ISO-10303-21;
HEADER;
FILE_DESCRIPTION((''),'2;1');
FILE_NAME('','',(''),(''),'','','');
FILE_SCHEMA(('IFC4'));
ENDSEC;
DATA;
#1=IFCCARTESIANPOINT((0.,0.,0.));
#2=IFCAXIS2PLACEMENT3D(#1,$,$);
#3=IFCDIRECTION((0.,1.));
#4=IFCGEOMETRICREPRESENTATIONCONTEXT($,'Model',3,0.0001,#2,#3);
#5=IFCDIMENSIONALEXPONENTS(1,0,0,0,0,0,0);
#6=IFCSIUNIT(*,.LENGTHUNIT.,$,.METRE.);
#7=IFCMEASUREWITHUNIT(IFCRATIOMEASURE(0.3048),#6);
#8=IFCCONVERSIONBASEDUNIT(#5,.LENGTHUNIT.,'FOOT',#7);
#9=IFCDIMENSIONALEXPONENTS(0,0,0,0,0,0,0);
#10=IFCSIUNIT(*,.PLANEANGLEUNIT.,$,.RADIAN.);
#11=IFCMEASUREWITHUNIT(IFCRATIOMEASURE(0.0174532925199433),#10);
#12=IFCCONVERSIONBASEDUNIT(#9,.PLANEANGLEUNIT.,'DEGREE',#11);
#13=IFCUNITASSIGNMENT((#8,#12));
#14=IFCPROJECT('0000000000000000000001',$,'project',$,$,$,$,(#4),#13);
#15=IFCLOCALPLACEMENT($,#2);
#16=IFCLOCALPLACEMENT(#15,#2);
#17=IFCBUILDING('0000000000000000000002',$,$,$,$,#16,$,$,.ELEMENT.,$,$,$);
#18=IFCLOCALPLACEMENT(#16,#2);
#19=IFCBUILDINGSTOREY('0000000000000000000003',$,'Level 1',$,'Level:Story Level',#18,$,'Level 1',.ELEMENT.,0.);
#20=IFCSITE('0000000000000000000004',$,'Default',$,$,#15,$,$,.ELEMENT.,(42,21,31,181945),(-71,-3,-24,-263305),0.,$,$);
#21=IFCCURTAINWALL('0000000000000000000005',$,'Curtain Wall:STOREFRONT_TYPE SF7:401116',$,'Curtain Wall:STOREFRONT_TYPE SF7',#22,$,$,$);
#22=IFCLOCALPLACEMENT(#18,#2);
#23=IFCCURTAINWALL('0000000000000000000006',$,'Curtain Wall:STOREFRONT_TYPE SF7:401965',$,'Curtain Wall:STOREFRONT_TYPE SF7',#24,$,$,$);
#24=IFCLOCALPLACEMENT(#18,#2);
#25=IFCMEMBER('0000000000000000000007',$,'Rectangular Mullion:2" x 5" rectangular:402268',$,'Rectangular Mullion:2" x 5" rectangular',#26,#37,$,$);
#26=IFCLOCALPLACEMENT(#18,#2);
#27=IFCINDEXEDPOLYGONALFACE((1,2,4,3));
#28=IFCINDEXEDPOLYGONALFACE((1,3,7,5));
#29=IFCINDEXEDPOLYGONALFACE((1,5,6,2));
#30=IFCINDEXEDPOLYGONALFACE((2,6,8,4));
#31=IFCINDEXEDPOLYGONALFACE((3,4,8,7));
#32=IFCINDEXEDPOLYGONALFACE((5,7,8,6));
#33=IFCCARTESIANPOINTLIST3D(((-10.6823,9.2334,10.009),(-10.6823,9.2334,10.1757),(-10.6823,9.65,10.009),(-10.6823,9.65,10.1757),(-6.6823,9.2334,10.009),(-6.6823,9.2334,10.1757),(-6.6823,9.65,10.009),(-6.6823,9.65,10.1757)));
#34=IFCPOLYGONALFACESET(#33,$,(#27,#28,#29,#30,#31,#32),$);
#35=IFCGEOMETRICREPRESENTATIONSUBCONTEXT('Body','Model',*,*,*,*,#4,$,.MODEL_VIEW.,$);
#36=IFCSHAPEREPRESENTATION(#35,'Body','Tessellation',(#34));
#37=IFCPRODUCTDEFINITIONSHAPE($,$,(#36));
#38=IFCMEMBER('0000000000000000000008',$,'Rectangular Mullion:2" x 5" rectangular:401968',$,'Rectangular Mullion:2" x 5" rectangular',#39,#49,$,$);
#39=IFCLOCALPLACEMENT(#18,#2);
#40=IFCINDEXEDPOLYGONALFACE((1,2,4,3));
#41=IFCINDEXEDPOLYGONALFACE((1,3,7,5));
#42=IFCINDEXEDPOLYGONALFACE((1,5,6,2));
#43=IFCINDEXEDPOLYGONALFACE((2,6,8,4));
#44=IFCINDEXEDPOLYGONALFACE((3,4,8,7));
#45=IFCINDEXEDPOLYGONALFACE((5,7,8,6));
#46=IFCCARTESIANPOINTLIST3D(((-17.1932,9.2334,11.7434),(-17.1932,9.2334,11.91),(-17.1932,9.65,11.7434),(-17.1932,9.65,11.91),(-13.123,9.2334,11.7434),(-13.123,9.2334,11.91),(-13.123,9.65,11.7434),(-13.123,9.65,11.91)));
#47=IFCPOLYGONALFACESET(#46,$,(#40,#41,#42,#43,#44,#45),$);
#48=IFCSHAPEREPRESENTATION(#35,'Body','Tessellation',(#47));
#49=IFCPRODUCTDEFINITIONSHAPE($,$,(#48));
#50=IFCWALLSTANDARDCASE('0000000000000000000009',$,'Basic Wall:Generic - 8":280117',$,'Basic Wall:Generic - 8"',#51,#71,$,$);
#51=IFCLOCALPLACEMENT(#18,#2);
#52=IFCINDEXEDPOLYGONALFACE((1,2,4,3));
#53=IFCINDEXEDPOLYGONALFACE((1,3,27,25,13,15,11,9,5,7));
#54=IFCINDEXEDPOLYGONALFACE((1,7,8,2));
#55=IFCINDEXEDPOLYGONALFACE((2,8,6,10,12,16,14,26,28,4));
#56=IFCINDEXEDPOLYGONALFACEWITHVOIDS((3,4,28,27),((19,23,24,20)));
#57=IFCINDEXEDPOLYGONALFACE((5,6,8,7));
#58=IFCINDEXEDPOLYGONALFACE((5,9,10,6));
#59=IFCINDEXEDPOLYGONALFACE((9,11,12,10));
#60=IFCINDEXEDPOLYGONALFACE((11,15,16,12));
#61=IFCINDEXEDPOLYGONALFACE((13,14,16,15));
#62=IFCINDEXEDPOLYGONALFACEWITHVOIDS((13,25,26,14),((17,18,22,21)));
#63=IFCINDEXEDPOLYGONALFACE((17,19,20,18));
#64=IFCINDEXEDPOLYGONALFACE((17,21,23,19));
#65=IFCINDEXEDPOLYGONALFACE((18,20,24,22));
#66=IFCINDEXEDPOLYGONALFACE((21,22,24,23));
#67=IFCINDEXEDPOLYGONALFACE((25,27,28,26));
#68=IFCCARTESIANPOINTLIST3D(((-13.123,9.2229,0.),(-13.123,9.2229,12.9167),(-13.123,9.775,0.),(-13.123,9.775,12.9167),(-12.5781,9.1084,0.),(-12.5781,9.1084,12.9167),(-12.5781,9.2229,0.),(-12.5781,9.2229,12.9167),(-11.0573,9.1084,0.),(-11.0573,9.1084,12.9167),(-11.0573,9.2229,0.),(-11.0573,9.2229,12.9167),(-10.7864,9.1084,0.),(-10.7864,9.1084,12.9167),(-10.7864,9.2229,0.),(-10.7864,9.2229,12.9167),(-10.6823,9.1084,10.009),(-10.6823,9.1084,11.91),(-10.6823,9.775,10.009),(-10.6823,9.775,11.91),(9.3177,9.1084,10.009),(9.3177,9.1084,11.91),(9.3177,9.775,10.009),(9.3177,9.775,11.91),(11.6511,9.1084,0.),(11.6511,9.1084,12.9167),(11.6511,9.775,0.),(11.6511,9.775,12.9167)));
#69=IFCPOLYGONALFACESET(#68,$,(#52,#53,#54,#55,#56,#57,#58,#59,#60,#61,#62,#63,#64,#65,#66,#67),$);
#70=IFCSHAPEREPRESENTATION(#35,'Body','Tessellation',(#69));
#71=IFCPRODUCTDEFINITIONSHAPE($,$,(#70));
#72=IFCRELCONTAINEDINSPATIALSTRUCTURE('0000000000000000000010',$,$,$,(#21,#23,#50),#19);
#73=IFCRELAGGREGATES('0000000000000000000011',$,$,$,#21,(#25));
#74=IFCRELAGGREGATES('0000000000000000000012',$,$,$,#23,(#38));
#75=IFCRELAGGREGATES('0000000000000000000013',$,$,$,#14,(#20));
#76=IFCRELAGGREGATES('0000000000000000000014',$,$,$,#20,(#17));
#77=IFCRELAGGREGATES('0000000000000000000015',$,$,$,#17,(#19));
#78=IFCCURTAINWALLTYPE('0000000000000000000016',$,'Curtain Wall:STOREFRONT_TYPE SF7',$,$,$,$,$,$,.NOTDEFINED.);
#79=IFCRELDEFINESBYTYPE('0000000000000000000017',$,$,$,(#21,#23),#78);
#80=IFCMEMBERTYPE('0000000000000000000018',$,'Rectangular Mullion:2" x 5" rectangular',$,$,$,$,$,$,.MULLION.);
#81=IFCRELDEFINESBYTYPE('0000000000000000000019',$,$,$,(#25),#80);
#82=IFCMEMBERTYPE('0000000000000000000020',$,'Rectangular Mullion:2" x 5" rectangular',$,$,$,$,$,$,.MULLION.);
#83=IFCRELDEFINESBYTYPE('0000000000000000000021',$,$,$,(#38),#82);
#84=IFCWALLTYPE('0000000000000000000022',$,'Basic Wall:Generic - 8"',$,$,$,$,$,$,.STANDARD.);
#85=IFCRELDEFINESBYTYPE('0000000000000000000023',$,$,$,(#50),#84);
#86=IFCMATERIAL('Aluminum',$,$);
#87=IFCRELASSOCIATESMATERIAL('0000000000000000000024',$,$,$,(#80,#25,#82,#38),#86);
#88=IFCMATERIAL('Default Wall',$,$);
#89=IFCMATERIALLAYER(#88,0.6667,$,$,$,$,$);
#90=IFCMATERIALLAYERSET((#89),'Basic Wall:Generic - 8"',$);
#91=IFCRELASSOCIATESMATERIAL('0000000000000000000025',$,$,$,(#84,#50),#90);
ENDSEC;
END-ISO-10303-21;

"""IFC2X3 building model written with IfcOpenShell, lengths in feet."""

from ifc_helpers import new_model, entity, si_unit, converted_unit, direction, frame, frame_2d, origin, origin_2d_with_axis, place, context, subcontext, project, spatial, polyline, rectangle, extrude, clip, bounded_halfspace, source, transform, mapped, material, layer, layer_set, layer_usage, type_object, type_shapes, element, aggregate, save


model = new_model("IFC2X3")

# Units and contexts
model_context = context("Model", 3, precision=0.0001, world=origin(), true_north=direction((0.0, 1.0)))
body_context = subcontext(model_context, "Body", "Model", "MODEL_VIEW")
ifc_project = project(units=[converted_unit("LENGTHUNIT", "FOOT", entity("IfcRatioMeasure", 0.3048), si_unit("LENGTHUNIT", "METRE"), dimensions=[1, 0, 0, 0, 0, 0, 0]), converted_unit("PLANEANGLEUNIT", "DEGREE", entity("IfcRatioMeasure", 0.0174532925199433), si_unit("PLANEANGLEUNIT", "RADIAN"), dimensions=[0, 0, 0, 0, 0, 0, 0])], contexts=[model_context])

# Site, building, storey
site_placement = place(None, origin())
site = spatial("IfcSite", under=ifc_project, at=site_placement, Name="Default", CompositionType="ELEMENT", RefLatitude=(42, 21, 31, 181945), RefLongitude=(-71, -3, -24, -263305), RefElevation=0.0)
building_placement = place(site_placement, origin())
building = spatial("IfcBuilding", under=site, at=building_placement, CompositionType="ELEMENT")
storey_placement = place(building_placement, origin())
storey = spatial("IfcBuildingStorey", under=building, at=storey_placement, Name="Level 1", ObjectType="Level:Story Level", LongName="Level 1", CompositionType="ELEMENT", Elevation=0.0)

# Curtain wall
curtain_wall_type = type_object("IfcCurtainWallType", Name="Curtain Wall:STOREFRONT_TYPE SF7", PredefinedType="NOTDEFINED")
curtain_wall_1_placement = place(storey_placement, origin())
curtain_wall_1 = element("IfcCurtainWall", 1, at=curtain_wall_1_placement, inside=storey, type_object=curtain_wall_type, Name="Curtain Wall:STOREFRONT_TYPE SF7:401116", ObjectType="Curtain Wall:STOREFRONT_TYPE SF7")
ifc_material_1 = material(Name="Aluminum")

# Curtain wall
curtain_wall_2_placement = place(storey_placement, origin())
curtain_wall_2 = element("IfcCurtainWall", 2, at=curtain_wall_2_placement, inside=storey, type_object=curtain_wall_type, Name="Curtain Wall:STOREFRONT_TYPE SF7:401965", ObjectType="Curtain Wall:STOREFRONT_TYPE SF7")

# Members
member_type_1 = type_object("IfcMemberType", Name="Rectangular Mullion:2\" x 5\" rectangular", PredefinedType="MULLION", material=ifc_material_1)
shared_shape_1 = source(origin(), body_context, "Body", "SweptSolid", [
    extrude(rectangle(XDim=0.4167, YDim=0.1667, at=origin_2d_with_axis()), frame((-0.0833, 0.0, -4.0), z_axis=(0.0, 0.0, 1.0), x_axis=(0.0, -1.0, 0.0)), (0.0, 0.0, 1.0), 4.0),
])
type_shapes(member_type_1, [shared_shape_1])
member_1_placement = place(curtain_wall_1_placement, frame((-6.6823, 9.4417, 10.009), z_axis=(1.0, 0.0, 0.0), x_axis=(0.0, 0.0, -1.0)))
member_1 = element("IfcMember", 3, at=member_1_placement, type_object=member_type_1, material=ifc_material_1, Name="Rectangular Mullion:2\" x 5\" rectangular:402268", ObjectType="Rectangular Mullion:2\" x 5\" rectangular", context=body_context, shape_type="MappedRepresentation", body=[
    mapped(shared_shape_1, transform((0.0, 0.0, 0.0), scale=1.0)),
])
member_type_2 = type_object("IfcMemberType", Name="Rectangular Mullion:2\" x 5\" rectangular", PredefinedType="MULLION", material=ifc_material_1)
shared_shape_2 = source(origin(), body_context, "Body", "SweptSolid", [
    extrude(rectangle(XDim=0.4167, YDim=0.1667, at=origin_2d_with_axis()), frame((-0.0833, 0.0, -4.0702), z_axis=(0.0, 0.0, 1.0), x_axis=(0.0, -1.0, 0.0)), (0.0, 0.0, 1.0), 4.0702),
])
type_shapes(member_type_2, [shared_shape_2])
member_2_placement = place(curtain_wall_2_placement, frame((-13.123, 9.4417, 11.91), z_axis=(1.0, 0.0, 0.0), x_axis=(0.0, 0.0, 1.0)))
member_2 = element("IfcMember", 4, at=member_2_placement, type_object=member_type_2, material=ifc_material_1, Name="Rectangular Mullion:2\" x 5\" rectangular:401968", ObjectType="Rectangular Mullion:2\" x 5\" rectangular", context=body_context, shape_type="MappedRepresentation", body=[
    mapped(shared_shape_2, transform((0.0, 0.0, 0.0), scale=1.0)),
])

aggregate(curtain_wall_1, [member_1])
aggregate(curtain_wall_2, [member_2])

# Wall, opening
ifc_material_2 = material(Name="Default Wall")
ifc_layer_1 = layer(ifc_material_2, 0.6667)
ifc_layer_set_1 = layer_set([ifc_layer_1], Name="Basic Wall:Generic - 8\"")
ifc_layer_usage_1 = layer_usage(ifc_layer_set_1, "AXIS2", "NEGATIVE", 0.3333)
wall_type_1 = type_object("IfcWallType", Name="Basic Wall:Generic - 8\"", PredefinedType="STANDARD", material=ifc_layer_set_1)
wall_1_placement = place(storey_placement, frame((-13.123, 9.4417, 0.0)))
wall_1 = element("IfcWallStandardCase", 5, at=wall_1_placement, inside=storey, type_object=wall_type_1, material=ifc_layer_usage_1, Name="Basic Wall:Generic - 8\":280117", ObjectType="Basic Wall:Generic - 8\"", context=body_context, shape_type="Clipping", body=[
    clip(clip(clip(extrude(rectangle(XDim=24.7741, YDim=0.6667, at=frame_2d((12.387, 0.0), x_axis=(-1.0, 0.0))), origin(), (0.0, 0.0, 1.0), 12.9167), bounded_halfspace(frame((0.5449, -0.2188, 0.0), z_axis=(0.0, 1.0, 0.0), x_axis=(-1.0, 0.0, 0.0)), True, frame((0.5449, -0.2188, 0.0), z_axis=(0.0, 1.0, 0.0), x_axis=(-1.0, 0.0, 0.0)), polyline([(0.0, 0.0), (0.5449, 0.0), (0.5449, 12.9167), (0.0, 12.9167), (0.0, 0.0)]))), bounded_halfspace(frame((0.5449, -0.2188, 12.9167), z_axis=(-1.0, 0.0, 0.0), x_axis=(0.0, -1.0, 0.0)), False, frame((0.5449, -0.2188, 12.9167), z_axis=(-1.0, 0.0, 0.0), x_axis=(0.0, -1.0, 0.0)), polyline([(0.0, 0.0), (0.0, -12.9167), (0.1146, -12.9167), (0.1146, 0.0), (0.0, 0.0)]))), bounded_halfspace(frame((2.0657, -0.2188, 12.9167), z_axis=(0.0, 1.0, 0.0), x_axis=(-1.0, 0.0, 0.0)), True, frame((2.0657, -0.2188, 12.9167), z_axis=(0.0, 1.0, 0.0), x_axis=(-1.0, 0.0, 0.0)), polyline([(0.0, 0.0), (-0.2708, 0.0), (-0.2708, -12.9167), (0.0, -12.9167), (0.0, 0.0)]))),
])
opening_1_placement = place(wall_1_placement, origin())
element("IfcOpeningElement", 6, at=opening_1_placement, cuts=wall_1, ObjectType="Opening", context=body_context, shape_type="SweptSolid", body=[
    extrude(rectangle(XDim=1.901, YDim=20.0, at=frame_2d((0.0, 0.0), x_axis=(0.0, 1.0))), frame((12.4407, -0.8333, 10.9595), z_axis=(0.0, 1.0, 0.0), x_axis=(-1.0, 0.0, 0.0)), (0.0, 0.0, 1.0), 1.6667),
])

save(model, "model.ifc")
